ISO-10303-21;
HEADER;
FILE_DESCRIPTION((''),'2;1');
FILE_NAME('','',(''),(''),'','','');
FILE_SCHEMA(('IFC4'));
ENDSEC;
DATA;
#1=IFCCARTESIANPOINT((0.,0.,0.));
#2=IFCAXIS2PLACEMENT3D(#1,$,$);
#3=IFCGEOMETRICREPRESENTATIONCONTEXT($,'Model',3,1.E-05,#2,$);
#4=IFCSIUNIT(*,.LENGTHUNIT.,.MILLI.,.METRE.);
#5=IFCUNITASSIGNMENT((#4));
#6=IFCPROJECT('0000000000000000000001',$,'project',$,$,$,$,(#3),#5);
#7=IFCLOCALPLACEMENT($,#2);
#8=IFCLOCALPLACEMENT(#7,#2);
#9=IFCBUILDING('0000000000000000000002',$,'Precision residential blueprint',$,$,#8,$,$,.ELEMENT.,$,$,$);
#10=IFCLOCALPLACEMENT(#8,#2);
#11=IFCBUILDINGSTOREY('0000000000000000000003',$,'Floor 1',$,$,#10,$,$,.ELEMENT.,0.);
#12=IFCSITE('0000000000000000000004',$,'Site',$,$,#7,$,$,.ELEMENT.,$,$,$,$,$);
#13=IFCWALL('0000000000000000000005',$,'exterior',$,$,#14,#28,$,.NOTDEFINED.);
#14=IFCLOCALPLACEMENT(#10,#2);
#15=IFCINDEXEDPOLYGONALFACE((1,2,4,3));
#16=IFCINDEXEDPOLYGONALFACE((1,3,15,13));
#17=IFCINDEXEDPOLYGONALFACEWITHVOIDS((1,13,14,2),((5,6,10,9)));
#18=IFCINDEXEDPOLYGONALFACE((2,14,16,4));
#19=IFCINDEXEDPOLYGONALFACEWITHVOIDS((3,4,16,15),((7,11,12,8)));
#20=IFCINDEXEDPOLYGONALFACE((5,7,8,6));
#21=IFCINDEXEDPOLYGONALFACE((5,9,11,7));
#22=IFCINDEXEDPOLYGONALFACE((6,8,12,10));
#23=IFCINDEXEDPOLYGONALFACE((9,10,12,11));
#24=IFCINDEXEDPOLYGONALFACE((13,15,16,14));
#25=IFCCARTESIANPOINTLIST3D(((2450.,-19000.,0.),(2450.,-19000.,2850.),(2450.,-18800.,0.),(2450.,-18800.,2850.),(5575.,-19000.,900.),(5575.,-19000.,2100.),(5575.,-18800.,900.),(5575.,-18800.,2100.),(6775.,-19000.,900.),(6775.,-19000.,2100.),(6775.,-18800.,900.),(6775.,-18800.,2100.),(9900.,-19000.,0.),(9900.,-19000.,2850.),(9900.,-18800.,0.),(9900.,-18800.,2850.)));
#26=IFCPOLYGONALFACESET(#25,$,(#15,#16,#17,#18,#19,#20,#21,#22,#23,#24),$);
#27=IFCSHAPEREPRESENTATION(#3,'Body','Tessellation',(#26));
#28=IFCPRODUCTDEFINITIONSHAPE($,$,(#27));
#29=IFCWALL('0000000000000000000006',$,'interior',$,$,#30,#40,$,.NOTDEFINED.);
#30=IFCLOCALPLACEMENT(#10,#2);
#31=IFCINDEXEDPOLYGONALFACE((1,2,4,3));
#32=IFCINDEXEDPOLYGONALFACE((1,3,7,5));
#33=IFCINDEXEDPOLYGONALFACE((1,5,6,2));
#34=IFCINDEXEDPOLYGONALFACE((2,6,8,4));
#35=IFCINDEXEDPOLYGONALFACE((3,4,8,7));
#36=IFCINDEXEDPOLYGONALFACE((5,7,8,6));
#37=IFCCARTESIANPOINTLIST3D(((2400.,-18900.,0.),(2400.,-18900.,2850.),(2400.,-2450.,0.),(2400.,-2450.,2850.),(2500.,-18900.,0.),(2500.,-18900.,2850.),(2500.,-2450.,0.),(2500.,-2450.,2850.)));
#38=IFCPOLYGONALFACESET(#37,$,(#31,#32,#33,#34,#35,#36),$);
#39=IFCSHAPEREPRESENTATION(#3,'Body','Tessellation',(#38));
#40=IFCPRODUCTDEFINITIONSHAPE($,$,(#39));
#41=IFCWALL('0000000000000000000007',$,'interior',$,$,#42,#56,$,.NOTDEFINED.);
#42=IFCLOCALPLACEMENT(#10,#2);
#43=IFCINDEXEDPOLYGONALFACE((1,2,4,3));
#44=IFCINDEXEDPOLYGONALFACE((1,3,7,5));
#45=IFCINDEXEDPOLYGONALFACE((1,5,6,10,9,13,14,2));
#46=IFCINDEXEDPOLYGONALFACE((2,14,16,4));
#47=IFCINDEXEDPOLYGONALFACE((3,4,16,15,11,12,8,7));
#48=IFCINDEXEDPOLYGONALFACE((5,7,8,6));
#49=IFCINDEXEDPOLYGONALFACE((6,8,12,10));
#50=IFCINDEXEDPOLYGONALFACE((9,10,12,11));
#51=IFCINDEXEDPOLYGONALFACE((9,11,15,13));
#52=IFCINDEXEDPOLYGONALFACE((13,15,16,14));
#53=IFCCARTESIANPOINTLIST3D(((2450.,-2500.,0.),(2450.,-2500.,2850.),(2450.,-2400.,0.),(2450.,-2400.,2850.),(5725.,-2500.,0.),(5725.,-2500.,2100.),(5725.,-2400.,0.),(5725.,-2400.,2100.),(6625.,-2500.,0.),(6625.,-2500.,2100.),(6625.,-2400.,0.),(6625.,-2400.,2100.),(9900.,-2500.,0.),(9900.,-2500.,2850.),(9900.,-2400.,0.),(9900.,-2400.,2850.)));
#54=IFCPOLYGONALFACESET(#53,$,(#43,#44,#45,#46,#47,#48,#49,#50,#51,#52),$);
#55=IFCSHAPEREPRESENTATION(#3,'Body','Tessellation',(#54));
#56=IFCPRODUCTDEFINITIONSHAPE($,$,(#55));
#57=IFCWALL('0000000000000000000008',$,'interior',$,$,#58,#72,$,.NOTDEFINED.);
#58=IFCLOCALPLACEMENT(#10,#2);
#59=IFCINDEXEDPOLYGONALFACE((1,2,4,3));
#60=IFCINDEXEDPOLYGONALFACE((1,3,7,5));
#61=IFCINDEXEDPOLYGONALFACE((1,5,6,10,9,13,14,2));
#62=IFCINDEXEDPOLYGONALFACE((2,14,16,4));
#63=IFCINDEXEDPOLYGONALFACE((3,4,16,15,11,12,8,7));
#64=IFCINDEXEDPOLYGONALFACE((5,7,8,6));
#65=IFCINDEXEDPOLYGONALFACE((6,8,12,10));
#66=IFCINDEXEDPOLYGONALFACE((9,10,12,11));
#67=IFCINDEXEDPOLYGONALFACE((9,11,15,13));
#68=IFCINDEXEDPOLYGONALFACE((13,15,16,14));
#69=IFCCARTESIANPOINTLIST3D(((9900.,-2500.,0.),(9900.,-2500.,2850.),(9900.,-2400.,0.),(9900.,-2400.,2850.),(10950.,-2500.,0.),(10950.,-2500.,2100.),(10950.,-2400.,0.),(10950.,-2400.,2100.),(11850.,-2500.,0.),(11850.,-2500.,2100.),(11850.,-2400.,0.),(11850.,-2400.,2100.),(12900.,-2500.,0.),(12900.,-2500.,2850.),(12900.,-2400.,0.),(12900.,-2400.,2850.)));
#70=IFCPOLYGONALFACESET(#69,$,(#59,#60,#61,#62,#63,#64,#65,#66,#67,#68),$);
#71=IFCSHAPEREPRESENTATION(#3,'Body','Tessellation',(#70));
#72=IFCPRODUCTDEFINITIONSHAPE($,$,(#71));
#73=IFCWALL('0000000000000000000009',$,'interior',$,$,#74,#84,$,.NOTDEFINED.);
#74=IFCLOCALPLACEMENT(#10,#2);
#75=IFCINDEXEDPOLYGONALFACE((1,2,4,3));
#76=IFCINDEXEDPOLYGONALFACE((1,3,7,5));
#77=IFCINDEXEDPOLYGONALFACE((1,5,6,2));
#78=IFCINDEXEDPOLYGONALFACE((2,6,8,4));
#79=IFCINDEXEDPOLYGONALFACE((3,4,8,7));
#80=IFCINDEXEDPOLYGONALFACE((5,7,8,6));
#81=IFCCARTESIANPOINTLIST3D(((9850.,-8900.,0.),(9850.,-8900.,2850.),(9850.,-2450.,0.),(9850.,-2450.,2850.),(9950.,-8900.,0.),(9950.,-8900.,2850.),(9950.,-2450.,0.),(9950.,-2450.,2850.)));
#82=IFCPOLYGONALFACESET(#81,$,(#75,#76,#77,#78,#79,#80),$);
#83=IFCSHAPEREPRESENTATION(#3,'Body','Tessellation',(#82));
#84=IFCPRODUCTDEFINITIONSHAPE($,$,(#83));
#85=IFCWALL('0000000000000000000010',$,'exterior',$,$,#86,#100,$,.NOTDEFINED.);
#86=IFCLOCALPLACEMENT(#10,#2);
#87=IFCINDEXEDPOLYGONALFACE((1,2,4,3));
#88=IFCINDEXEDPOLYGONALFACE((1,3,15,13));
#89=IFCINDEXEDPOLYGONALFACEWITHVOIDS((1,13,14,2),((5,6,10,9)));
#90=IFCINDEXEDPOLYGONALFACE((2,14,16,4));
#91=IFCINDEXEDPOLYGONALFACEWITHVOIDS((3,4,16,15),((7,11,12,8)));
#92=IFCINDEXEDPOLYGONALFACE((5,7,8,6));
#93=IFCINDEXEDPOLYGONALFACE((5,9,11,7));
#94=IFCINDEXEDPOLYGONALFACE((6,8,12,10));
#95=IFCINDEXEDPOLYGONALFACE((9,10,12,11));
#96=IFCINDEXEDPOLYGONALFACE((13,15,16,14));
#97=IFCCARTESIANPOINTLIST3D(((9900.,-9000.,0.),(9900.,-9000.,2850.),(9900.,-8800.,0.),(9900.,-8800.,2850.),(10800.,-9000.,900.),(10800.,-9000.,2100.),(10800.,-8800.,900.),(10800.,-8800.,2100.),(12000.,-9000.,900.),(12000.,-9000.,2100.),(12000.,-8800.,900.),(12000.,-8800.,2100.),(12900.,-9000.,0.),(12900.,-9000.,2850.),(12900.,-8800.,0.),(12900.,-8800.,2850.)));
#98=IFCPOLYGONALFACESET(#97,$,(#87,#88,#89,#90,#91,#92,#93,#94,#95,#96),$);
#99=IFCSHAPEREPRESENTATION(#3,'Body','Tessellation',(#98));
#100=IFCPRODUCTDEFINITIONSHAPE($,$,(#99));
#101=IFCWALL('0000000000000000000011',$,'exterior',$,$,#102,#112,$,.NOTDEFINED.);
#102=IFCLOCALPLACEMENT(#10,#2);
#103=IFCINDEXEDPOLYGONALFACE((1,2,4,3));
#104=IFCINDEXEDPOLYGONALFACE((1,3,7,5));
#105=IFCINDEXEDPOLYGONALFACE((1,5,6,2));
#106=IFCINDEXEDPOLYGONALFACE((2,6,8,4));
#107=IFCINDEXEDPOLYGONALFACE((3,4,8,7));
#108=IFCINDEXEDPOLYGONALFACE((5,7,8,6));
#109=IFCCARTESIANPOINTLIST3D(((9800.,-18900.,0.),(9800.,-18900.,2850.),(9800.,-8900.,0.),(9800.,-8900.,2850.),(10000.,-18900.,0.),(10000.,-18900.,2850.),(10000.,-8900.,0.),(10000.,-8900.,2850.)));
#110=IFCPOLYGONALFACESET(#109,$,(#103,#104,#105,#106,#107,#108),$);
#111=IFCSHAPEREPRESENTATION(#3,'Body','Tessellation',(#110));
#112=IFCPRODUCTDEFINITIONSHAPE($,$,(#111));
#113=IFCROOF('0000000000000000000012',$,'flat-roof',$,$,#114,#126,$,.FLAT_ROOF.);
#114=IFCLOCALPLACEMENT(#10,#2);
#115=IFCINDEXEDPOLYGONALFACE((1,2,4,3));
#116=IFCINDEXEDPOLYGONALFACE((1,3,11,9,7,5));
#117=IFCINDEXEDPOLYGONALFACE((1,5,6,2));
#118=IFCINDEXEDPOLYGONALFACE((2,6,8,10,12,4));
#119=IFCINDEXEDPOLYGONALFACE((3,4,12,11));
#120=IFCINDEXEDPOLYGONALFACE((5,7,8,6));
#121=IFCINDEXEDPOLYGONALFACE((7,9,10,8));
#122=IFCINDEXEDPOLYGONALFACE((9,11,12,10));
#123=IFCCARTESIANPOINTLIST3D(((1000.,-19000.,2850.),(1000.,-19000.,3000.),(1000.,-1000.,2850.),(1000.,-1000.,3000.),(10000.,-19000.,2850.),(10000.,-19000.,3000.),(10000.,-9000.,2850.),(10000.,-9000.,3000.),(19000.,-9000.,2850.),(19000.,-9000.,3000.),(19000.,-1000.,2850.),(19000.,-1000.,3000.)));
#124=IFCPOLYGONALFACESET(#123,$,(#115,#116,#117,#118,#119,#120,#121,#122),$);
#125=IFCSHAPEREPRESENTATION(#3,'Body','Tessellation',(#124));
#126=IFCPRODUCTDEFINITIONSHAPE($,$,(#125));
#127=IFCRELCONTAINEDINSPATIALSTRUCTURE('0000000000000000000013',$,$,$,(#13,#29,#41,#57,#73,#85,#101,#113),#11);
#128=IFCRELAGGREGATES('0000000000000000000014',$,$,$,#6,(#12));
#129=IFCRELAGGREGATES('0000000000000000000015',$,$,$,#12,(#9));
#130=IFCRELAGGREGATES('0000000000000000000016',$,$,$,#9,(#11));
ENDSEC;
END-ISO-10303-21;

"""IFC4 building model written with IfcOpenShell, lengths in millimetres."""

from ifc_helpers import new_model, si_unit, frame, origin, place, context, project, spatial, polyline, outline, extrude, element, save


model = new_model("IFC4")

# Units and contexts
model_context = context("Model", 3, precision=1e-05, world=origin())
ifc_project = project(units=[si_unit("LENGTHUNIT", "METRE", prefix="MILLI")], contexts=[model_context])

# Site, building, storey
site_placement = place(None, origin())
site = spatial("IfcSite", under=ifc_project, at=site_placement, Name="Site", CompositionType="ELEMENT")
building_placement = place(site_placement, origin())
building = spatial("IfcBuilding", under=site, at=building_placement, Name="Precision residential blueprint", CompositionType="ELEMENT")
storey_placement = place(building_placement, origin())
storey = spatial("IfcBuildingStorey", under=building, at=storey_placement, Name="Floor 1", CompositionType="ELEMENT", Elevation=0.0)

# Wall, opening
wall_1_placement = place(storey_placement, origin())
wall_1 = element("IfcWall", 1, at=wall_1_placement, inside=storey, Name="exterior", PredefinedType="NOTDEFINED", context=model_context, shape_type="SweptSolid", body=[
    extrude(outline(polyline([(2450.0, -18800.0), (9900.0, -18800.0), (9900.0, -19000.0), (2450.0, -19000.0), (2450.0, -18800.0)])), origin(), (0.0, 0.0, 1.0), 2850.0),
])
opening_1_placement = place(storey_placement, origin())
element("IfcOpeningElement", 2, at=opening_1_placement, cuts=wall_1, PredefinedType="OPENING", context=model_context, shape_type="SweptSolid", body=[
    extrude(outline(polyline([(5575.0, -18800.0), (6775.0, -18800.0), (6775.0, -19000.0), (5575.0, -19000.0), (5575.0, -18800.0)])), frame((0.0, 0.0, 900.0)), (0.0, 0.0, 1.0), 1200.0),
])

# Wall
wall_2_placement = place(storey_placement, origin())
element("IfcWall", 3, at=wall_2_placement, inside=storey, Name="interior", PredefinedType="NOTDEFINED", context=model_context, shape_type="SweptSolid", body=[
    extrude(outline(polyline([(2500.0, -2450.0), (2500.0, -18900.0), (2400.0, -18900.0), (2400.0, -2450.0), (2500.0, -2450.0)])), origin(), (0.0, 0.0, 1.0), 2850.0),
])

# Walls, openings
wall_3_placement = place(storey_placement, origin())
wall_3 = element("IfcWall", 4, at=wall_3_placement, inside=storey, Name="interior", PredefinedType="NOTDEFINED", context=model_context, shape_type="SweptSolid", body=[
    extrude(outline(polyline([(2450.0, -2400.0), (9900.0, -2400.0), (9900.0, -2500.0), (2450.0, -2500.0), (2450.0, -2400.0)])), origin(), (0.0, 0.0, 1.0), 2850.0),
])
opening_2_placement = place(storey_placement, origin())
element("IfcOpeningElement", 5, at=opening_2_placement, cuts=wall_3, PredefinedType="OPENING", context=model_context, shape_type="SweptSolid", body=[
    extrude(outline(polyline([(5725.0, -2400.0), (6625.0, -2400.0), (6625.0, -2500.0), (5725.0, -2500.0), (5725.0, -2400.0)])), origin(), (0.0, 0.0, 1.0), 2100.0),
])
wall_4_placement = place(storey_placement, origin())
wall_4 = element("IfcWall", 6, at=wall_4_placement, inside=storey, Name="interior", PredefinedType="NOTDEFINED", context=model_context, shape_type="SweptSolid", body=[
    extrude(outline(polyline([(9900.0, -2400.0), (12900.0, -2400.0), (12900.0, -2500.0), (9900.0, -2500.0), (9900.0, -2400.0)])), origin(), (0.0, 0.0, 1.0), 2850.0),
])
opening_3_placement = place(storey_placement, origin())
element("IfcOpeningElement", 7, at=opening_3_placement, cuts=wall_4, PredefinedType="OPENING", context=model_context, shape_type="SweptSolid", body=[
    extrude(outline(polyline([(10950.0, -2400.0), (11850.0, -2400.0), (11850.0, -2500.0), (10950.0, -2500.0), (10950.0, -2400.0)])), origin(), (0.0, 0.0, 1.0), 2100.0),
])

# Wall
wall_5_placement = place(storey_placement, origin())
element("IfcWall", 8, at=wall_5_placement, inside=storey, Name="interior", PredefinedType="NOTDEFINED", context=model_context, shape_type="SweptSolid", body=[
    extrude(outline(polyline([(9950.0, -2450.0), (9950.0, -8900.0), (9850.0, -8900.0), (9850.0, -2450.0), (9950.0, -2450.0)])), origin(), (0.0, 0.0, 1.0), 2850.0),
])

# Wall, opening
wall_6_placement = place(storey_placement, origin())
wall_6 = element("IfcWall", 9, at=wall_6_placement, inside=storey, Name="exterior", PredefinedType="NOTDEFINED", context=model_context, shape_type="SweptSolid", body=[
    extrude(outline(polyline([(9900.0, -8800.0), (12900.0, -8800.0), (12900.0, -9000.0), (9900.0, -9000.0), (9900.0, -8800.0)])), origin(), (0.0, 0.0, 1.0), 2850.0),
])
opening_4_placement = place(storey_placement, origin())
element("IfcOpeningElement", 10, at=opening_4_placement, cuts=wall_6, PredefinedType="OPENING", context=model_context, shape_type="SweptSolid", body=[
    extrude(outline(polyline([(10800.0, -8800.0), (12000.0, -8800.0), (12000.0, -9000.0), (10800.0, -9000.0), (10800.0, -8800.0)])), frame((0.0, 0.0, 900.0)), (0.0, 0.0, 1.0), 1200.0),
])

# Wall
wall_7_placement = place(storey_placement, origin())
element("IfcWall", 11, at=wall_7_placement, inside=storey, Name="exterior", PredefinedType="NOTDEFINED", context=model_context, shape_type="SweptSolid", body=[
    extrude(outline(polyline([(10000.0, -8900.0), (10000.0, -18900.0), (9800.0, -18900.0), (9800.0, -8900.0), (10000.0, -8900.0)])), origin(), (0.0, 0.0, 1.0), 2850.0),
])

# Roof
roof_placement = place(storey_placement, origin())
element("IfcRoof", 12, at=roof_placement, inside=storey, Name="flat-roof", PredefinedType="FLAT_ROOF", context=model_context, shape_type="SweptSolid", body=[
    extrude(outline(polyline([(1000.0, -19000.0), (10000.0, -19000.0), (10000.0, -9000.0), (19000.0, -9000.0), (19000.0, -1000.0), (1000.0, -1000.0), (1000.0, -19000.0)])), frame((0.0, 0.0, 2850.0)), (0.0, 0.0, 1.0), 150.0),
])

save(model, "model.ifc")
